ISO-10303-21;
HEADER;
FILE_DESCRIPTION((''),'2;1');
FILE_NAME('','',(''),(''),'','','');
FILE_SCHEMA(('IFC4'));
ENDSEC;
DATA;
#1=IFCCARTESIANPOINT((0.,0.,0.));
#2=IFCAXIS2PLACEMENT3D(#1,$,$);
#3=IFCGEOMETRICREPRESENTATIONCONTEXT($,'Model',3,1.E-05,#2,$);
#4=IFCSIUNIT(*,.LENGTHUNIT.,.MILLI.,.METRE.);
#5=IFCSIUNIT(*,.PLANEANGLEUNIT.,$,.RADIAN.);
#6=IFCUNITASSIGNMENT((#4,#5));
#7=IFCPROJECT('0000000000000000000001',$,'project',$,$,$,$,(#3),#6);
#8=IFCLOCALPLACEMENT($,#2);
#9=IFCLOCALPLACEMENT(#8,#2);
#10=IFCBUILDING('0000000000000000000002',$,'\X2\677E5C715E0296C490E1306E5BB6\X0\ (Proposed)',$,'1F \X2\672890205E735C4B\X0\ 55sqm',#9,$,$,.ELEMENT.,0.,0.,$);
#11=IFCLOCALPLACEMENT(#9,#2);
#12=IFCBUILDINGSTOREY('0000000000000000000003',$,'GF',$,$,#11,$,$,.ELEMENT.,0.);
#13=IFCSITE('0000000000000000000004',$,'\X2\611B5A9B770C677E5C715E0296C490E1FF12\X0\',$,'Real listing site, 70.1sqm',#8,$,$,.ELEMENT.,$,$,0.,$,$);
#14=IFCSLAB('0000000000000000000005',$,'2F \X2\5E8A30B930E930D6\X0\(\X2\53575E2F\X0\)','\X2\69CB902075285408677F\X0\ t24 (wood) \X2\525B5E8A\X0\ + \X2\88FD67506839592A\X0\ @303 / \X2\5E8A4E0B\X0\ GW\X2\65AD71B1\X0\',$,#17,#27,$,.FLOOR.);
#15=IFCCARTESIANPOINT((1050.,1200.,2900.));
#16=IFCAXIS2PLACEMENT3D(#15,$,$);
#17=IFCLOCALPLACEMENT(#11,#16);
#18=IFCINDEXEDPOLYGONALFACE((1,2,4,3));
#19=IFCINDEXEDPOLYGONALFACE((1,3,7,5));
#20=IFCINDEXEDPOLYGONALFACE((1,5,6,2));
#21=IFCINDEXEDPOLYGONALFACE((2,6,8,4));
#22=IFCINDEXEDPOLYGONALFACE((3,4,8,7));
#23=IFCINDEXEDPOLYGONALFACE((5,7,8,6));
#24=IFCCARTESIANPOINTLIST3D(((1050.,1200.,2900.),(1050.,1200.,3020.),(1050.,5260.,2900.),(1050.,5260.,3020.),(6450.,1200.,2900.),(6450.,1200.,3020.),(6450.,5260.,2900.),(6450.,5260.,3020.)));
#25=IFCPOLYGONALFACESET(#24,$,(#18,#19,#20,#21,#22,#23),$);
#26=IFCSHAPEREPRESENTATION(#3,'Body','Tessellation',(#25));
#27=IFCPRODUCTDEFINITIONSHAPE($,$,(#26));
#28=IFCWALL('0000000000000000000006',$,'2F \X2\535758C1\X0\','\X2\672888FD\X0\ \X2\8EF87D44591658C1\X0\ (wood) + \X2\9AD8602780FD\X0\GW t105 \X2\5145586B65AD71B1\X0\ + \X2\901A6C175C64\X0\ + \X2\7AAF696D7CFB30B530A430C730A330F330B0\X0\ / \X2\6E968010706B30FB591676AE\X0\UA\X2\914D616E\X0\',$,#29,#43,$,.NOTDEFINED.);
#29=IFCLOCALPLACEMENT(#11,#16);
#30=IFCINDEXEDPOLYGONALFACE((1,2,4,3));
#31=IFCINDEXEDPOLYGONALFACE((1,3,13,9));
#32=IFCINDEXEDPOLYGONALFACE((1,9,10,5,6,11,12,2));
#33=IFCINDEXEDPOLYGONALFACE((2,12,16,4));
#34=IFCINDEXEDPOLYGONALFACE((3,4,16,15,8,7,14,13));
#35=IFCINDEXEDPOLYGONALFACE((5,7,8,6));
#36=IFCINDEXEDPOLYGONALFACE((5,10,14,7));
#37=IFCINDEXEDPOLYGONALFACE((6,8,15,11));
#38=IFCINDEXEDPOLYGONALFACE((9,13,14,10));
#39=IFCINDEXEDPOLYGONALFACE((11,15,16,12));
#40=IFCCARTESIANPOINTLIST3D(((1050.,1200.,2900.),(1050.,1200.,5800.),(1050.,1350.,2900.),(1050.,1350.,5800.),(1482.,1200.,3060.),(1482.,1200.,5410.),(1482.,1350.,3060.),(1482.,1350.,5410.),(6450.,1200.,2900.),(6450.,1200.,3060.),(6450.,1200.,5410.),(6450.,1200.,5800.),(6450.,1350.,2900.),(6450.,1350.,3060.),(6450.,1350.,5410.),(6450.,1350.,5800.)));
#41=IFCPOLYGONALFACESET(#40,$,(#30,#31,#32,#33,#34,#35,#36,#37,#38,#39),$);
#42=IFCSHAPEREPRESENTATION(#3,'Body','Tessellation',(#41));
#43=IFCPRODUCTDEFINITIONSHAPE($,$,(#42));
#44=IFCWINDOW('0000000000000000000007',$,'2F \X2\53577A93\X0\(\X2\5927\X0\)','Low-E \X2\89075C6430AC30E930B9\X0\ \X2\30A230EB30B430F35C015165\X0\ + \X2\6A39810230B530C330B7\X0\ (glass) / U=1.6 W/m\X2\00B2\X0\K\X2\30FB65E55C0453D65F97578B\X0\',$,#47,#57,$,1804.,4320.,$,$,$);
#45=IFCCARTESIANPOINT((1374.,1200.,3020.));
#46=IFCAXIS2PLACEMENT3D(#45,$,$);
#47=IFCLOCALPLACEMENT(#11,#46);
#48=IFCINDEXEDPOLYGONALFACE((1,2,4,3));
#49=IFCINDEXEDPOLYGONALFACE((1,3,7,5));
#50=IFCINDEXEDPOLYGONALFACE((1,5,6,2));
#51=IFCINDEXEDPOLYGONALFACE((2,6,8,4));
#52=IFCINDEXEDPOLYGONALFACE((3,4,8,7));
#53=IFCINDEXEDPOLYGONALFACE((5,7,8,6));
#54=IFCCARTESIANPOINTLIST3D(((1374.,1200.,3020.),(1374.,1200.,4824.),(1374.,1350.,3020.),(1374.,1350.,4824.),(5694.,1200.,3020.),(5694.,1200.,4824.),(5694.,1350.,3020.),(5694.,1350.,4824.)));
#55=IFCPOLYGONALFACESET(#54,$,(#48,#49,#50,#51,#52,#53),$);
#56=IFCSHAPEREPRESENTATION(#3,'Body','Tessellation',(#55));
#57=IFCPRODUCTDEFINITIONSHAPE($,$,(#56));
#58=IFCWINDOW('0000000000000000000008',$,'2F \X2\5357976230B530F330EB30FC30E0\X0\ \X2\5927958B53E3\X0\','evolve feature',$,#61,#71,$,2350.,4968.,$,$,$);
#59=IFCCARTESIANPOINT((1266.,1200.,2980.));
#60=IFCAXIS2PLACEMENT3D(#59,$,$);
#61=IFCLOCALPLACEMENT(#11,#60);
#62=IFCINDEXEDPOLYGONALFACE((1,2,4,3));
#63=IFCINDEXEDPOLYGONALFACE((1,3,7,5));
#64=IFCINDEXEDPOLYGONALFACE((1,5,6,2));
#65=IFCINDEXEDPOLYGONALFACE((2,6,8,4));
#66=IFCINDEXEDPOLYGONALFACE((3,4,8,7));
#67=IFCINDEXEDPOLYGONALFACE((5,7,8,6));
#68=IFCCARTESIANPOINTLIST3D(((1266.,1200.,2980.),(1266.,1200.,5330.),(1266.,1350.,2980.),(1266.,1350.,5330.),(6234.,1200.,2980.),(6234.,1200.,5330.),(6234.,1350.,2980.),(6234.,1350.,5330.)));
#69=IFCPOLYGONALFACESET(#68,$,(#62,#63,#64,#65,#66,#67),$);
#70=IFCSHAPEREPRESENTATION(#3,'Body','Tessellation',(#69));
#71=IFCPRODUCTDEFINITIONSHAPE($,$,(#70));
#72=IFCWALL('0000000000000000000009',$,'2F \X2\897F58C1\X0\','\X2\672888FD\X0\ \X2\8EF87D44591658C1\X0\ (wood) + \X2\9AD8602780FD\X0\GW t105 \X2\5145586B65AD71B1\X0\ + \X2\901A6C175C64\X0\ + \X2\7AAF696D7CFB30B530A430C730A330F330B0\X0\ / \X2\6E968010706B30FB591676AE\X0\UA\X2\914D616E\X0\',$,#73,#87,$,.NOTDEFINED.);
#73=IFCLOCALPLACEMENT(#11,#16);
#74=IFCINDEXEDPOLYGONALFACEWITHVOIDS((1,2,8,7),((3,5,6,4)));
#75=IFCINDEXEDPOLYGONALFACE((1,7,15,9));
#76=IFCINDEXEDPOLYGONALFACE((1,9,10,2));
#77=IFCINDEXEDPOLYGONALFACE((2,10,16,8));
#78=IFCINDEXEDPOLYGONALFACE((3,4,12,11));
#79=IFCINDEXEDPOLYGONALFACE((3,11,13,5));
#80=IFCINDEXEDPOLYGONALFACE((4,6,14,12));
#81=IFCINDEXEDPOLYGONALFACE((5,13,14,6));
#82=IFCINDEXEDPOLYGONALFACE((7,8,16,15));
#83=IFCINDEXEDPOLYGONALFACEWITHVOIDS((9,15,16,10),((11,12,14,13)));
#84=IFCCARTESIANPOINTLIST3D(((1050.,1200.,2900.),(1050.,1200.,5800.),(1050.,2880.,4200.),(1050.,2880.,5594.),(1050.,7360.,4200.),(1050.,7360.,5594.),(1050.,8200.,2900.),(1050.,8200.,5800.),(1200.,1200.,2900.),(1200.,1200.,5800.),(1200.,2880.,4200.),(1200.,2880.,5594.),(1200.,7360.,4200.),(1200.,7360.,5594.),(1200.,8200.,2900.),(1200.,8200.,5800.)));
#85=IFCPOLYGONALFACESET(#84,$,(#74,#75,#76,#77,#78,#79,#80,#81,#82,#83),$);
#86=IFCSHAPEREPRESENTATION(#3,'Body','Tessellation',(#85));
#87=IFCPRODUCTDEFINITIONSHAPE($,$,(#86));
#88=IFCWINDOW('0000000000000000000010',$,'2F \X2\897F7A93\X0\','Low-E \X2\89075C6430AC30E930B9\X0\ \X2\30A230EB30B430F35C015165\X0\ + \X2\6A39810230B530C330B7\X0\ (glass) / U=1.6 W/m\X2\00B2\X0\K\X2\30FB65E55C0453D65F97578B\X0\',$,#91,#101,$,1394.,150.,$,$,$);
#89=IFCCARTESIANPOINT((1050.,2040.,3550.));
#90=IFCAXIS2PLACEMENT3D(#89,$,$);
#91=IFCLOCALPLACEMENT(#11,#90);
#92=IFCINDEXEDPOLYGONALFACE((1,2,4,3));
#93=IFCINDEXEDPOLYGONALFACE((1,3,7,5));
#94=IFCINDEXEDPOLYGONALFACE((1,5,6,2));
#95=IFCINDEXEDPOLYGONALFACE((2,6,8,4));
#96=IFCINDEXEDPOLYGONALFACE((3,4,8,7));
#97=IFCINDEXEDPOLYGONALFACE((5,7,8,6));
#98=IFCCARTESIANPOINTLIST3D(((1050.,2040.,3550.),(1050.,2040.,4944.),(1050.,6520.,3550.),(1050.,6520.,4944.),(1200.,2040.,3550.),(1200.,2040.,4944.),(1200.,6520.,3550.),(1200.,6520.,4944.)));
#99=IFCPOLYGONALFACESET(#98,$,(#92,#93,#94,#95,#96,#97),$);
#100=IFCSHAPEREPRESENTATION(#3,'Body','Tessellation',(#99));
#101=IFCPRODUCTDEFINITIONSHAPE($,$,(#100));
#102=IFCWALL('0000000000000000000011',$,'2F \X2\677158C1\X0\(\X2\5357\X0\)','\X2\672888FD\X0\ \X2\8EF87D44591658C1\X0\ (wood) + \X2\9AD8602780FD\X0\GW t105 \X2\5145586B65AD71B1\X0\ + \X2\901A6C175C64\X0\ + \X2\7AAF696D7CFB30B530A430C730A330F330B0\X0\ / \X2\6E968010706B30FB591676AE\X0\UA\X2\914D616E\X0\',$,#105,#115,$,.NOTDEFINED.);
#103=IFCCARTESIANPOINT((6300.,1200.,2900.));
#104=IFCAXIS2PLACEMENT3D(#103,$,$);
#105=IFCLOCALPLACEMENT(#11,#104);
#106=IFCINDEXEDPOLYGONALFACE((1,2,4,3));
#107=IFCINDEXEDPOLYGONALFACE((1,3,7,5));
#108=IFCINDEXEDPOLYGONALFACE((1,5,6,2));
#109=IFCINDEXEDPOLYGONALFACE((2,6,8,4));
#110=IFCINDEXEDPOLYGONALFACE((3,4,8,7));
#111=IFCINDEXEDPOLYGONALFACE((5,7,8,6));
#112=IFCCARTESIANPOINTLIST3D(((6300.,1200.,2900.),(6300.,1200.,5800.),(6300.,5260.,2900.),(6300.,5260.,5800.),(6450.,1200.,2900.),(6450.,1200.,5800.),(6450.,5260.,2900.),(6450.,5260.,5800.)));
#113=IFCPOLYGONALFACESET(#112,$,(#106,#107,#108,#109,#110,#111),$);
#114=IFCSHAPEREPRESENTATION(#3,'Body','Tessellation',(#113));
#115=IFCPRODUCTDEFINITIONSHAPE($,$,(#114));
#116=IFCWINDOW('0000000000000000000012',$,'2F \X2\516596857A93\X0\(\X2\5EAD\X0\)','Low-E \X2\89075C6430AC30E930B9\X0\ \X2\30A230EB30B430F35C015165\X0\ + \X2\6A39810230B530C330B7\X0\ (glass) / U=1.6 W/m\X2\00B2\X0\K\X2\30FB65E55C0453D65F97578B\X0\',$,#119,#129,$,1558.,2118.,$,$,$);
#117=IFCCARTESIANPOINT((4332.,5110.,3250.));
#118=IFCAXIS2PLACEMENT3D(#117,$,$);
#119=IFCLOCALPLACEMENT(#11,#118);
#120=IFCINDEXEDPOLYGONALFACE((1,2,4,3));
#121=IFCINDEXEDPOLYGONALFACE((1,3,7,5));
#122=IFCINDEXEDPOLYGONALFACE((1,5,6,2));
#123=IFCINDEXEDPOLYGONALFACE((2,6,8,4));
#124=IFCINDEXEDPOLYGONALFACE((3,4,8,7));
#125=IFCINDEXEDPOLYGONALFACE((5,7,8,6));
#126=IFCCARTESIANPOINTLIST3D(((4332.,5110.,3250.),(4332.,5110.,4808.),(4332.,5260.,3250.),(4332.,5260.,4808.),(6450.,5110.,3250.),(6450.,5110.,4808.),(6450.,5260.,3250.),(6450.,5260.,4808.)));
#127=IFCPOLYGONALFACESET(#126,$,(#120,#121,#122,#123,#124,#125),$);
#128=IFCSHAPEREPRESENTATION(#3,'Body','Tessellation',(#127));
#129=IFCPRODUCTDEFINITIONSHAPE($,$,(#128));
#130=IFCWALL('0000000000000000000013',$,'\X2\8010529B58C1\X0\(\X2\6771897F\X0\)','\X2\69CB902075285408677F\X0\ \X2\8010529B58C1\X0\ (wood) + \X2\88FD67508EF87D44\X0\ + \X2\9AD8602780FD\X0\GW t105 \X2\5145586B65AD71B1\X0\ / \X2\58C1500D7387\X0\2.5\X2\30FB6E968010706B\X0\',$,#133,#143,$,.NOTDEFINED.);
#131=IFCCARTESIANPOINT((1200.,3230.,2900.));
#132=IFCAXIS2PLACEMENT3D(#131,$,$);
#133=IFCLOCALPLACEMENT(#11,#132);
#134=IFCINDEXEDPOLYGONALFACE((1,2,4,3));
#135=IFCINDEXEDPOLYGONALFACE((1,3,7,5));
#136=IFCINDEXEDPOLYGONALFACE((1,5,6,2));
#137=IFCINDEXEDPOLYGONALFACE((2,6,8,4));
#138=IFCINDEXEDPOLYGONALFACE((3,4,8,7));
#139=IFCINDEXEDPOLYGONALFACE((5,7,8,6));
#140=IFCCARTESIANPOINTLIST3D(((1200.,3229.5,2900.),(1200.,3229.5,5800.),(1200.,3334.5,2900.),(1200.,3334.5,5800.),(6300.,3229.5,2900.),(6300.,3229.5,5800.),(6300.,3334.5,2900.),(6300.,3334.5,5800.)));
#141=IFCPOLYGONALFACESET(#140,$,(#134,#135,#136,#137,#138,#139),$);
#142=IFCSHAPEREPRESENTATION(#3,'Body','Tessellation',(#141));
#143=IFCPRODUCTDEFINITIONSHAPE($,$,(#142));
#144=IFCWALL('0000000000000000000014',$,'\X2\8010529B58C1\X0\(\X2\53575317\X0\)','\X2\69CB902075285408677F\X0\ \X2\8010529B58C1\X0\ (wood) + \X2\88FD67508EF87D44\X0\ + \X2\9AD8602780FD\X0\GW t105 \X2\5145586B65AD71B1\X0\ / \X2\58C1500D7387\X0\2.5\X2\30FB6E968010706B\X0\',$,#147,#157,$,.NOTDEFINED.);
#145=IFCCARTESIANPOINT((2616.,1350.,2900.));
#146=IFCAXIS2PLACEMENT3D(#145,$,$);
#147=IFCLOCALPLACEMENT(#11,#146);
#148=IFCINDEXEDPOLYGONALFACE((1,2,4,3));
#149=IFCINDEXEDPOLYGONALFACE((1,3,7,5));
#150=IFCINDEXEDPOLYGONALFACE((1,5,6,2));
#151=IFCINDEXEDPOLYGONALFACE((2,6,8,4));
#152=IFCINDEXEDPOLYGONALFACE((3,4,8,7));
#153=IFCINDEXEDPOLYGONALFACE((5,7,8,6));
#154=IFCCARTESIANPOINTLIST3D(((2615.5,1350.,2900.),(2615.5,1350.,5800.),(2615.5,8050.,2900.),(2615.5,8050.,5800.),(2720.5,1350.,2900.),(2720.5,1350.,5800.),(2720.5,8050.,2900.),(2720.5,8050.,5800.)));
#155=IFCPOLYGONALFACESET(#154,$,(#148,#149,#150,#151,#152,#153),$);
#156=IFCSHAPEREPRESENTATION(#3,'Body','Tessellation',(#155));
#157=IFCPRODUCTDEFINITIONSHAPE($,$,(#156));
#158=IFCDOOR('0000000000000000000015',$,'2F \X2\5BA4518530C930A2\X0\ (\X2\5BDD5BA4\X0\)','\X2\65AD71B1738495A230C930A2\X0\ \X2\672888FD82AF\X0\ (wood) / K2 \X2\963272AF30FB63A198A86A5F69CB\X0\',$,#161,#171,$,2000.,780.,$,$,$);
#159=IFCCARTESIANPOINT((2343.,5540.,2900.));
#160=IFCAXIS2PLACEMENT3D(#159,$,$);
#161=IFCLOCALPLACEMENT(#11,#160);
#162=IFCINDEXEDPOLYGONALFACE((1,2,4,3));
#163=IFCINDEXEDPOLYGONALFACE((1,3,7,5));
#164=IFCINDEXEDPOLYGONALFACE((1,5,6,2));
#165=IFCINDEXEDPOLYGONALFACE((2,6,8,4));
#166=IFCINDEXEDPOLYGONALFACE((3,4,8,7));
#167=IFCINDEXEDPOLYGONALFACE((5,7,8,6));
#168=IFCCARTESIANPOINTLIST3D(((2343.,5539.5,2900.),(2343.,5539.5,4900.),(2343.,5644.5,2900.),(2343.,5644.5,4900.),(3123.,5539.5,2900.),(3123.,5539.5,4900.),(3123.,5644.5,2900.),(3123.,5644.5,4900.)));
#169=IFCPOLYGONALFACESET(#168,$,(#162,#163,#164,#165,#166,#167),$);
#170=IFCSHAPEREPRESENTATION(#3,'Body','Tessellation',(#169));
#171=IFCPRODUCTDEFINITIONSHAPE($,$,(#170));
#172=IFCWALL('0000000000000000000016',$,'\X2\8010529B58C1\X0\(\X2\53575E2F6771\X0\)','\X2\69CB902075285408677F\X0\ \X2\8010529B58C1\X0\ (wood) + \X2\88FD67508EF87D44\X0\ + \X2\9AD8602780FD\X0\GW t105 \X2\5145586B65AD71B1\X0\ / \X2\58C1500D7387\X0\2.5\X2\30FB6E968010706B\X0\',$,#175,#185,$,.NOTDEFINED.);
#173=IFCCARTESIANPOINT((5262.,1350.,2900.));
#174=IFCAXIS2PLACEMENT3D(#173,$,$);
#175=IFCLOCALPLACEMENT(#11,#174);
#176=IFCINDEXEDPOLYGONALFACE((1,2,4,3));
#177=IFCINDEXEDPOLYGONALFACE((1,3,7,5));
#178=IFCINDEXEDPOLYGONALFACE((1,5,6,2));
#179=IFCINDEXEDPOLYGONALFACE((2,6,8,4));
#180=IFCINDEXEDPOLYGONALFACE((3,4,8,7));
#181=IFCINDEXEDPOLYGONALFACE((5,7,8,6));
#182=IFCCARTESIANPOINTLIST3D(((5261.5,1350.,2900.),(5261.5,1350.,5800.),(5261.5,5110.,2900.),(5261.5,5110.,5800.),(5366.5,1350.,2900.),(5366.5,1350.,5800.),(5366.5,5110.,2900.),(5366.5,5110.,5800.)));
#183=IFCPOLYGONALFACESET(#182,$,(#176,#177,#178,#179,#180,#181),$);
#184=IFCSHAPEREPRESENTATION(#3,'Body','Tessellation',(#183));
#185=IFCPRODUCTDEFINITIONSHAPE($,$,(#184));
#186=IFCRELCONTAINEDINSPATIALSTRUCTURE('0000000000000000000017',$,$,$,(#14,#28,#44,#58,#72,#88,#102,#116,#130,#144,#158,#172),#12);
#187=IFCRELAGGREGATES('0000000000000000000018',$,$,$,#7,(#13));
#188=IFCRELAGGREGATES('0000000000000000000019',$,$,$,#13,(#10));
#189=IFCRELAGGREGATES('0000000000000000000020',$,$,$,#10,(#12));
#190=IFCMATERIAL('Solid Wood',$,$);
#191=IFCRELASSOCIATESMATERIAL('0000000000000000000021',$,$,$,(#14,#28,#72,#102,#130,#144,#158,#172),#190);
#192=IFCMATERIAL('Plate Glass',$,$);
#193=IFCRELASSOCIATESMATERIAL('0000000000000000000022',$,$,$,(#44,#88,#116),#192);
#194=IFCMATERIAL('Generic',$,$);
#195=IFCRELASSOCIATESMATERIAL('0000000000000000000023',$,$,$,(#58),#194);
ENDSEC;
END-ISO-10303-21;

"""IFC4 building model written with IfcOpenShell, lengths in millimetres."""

from ifc_helpers import new_model, si_unit, frame, frame_2d, origin, place, context, project, spatial, rectangle, extrude, material, element, fill, save


model = new_model("IFC4")

# Units and contexts
model_context = context("Model", 3, precision=1e-05, world=origin())
ifc_project = project(units=[si_unit("LENGTHUNIT", "METRE", prefix="MILLI"), si_unit("PLANEANGLEUNIT", "RADIAN")], contexts=[model_context])

# Site, building, storey
site_placement = place(None, origin())
site = spatial("IfcSite", under=ifc_project, at=site_placement, Name="愛媛県松山市雄郡２", ObjectType="Real listing site, 70.1sqm", CompositionType="ELEMENT", RefElevation=0.0)
building_placement = place(site_placement, origin())
building = spatial("IfcBuilding", under=site, at=building_placement, Name="松山市雄郡の家 (Proposed)", ObjectType="1F 木造平屋 55sqm", CompositionType="ELEMENT", ElevationOfRefHeight=0.0, ElevationOfTerrain=0.0)
storey_placement = place(building_placement, origin())
storey = spatial("IfcBuildingStorey", under=building, at=storey_placement, Name="GF", CompositionType="ELEMENT", Elevation=0.0)

# Slab
ifc_material_1 = material(Name="Solid Wood")
slab_placement = place(storey_placement, frame((1050.0, 1200.0, 2900.0)))
element("IfcSlab", 1, at=slab_placement, inside=storey, material=ifc_material_1, Name="2F 床スラブ(南帯)", Description="構造用合板 t24 (wood) 剛床 + 製材根太 @303 / 床下 GW断熱", PredefinedType="FLOOR", context=model_context, shape_type="SweptSolid", body=[
    extrude(rectangle(XDim=5400.0, YDim=4060.0, at=frame_2d((2700.0, 2030.0))), frame((1050.0, 1200.0, 2900.0)), (0.0, 0.0, 1.0), 120.0),
])

# Wall, openings, windows
wall_1_placement = place(storey_placement, frame((1050.0, 1200.0, 2900.0)))
wall_1 = element("IfcWall", 2, at=wall_1_placement, inside=storey, material=ifc_material_1, Name="2F 南壁", Description="木製 軸組外壁 (wood) + 高性能GW t105 充填断熱 + 通気層 + 窯業系サイディング / 準耐火・外皮UA配慮", PredefinedType="NOTDEFINED", context=model_context, shape_type="SweptSolid", body=[
    extrude(rectangle(XDim=5400.0, YDim=150.0, at=frame_2d((2700.0, 75.0))), frame((1050.0, 1200.0, 2900.0)), (0.0, 0.0, 1.0), 2900.0),
])
opening_1_placement = place(storey_placement, frame((1374.0, 1200.0, 3020.0)))
opening_1 = element("IfcOpeningElement", 3, at=opening_1_placement, cuts=wall_1, PredefinedType="NOTDEFINED", context=model_context, shape_type="SweptSolid", body=[
    extrude(rectangle(XDim=4320.0, YDim=150.0, at=frame_2d((2160.0, 75.0))), frame((1374.0, 1200.0, 3020.0)), (0.0, 0.0, 1.0), 1804.0),
])
opening_2_placement = place(storey_placement, frame((1266.0, 1200.0, 2980.0)))
opening_2 = element("IfcOpeningElement", 4, at=opening_2_placement, cuts=wall_1, PredefinedType="NOTDEFINED", context=model_context, shape_type="SweptSolid", body=[
    extrude(rectangle(XDim=4968.0, YDim=150.0, at=frame_2d((2484.0, 75.0))), frame((1266.0, 1200.0, 2980.0)), (0.0, 0.0, 1.0), 2350.0),
])
ifc_material_2 = material(Name="Plate Glass")
window_1_placement = place(storey_placement, frame((1374.0, 1200.0, 3020.0)))
window_1 = element("IfcWindow", 5, at=window_1_placement, inside=storey, material=ifc_material_2, Name="2F 南窓(大)", Description="Low-E 複層ガラス アルゴン封入 + 樹脂サッシ (glass) / U=1.6 W/m²K・日射取得型", OverallHeight=1804.0, OverallWidth=4320.0, context=model_context, shape_type="SweptSolid", body=[
    extrude(rectangle(XDim=4320.0, YDim=150.0, at=frame_2d((2160.0, 75.0))), frame((1374.0, 1200.0, 3020.0)), (0.0, 0.0, 1.0), 1804.0),
])
fill(opening_1, window_1)
ifc_material_3 = material(Name="Generic")
window_2_placement = place(storey_placement, frame((1266.0, 1200.0, 2980.0)))
window_2 = element("IfcWindow", 6, at=window_2_placement, inside=storey, material=ifc_material_3, Name="2F 南面サンルーム 大開口", Description="evolve feature", OverallHeight=2350.0, OverallWidth=4968.0, context=model_context, shape_type="SweptSolid", body=[
    extrude(rectangle(XDim=4968.0, YDim=150.0, at=frame_2d((2484.0, 75.0))), frame((1266.0, 1200.0, 2980.0)), (0.0, 0.0, 1.0), 2350.0),
])
fill(opening_2, window_2)

# Walls, openings, windows
wall_2_placement = place(storey_placement, frame((1050.0, 1200.0, 2900.0)))
wall_2 = element("IfcWall", 7, at=wall_2_placement, inside=storey, material=ifc_material_1, Name="2F 西壁", Description="木製 軸組外壁 (wood) + 高性能GW t105 充填断熱 + 通気層 + 窯業系サイディング / 準耐火・外皮UA配慮", PredefinedType="NOTDEFINED", context=model_context, shape_type="SweptSolid", body=[
    extrude(rectangle(XDim=150.0, YDim=7000.0, at=frame_2d((75.0, 3500.0))), frame((1050.0, 1200.0, 2900.0)), (0.0, 0.0, 1.0), 2900.0),
])
opening_3_placement = place(storey_placement, frame((1050.0, 2040.0, 3550.0)))
opening_3 = element("IfcOpeningElement", 8, at=opening_3_placement, cuts=wall_2, PredefinedType="NOTDEFINED", context=model_context, shape_type="SweptSolid", body=[
    extrude(rectangle(XDim=150.0, YDim=4480.0, at=frame_2d((75.0, 2240.0))), frame((1050.0, 2040.0, 3550.0)), (0.0, 0.0, 1.0), 1394.0),
])
window_3_placement = place(storey_placement, frame((1050.0, 2040.0, 3550.0)))
window_3 = element("IfcWindow", 9, at=window_3_placement, inside=storey, material=ifc_material_2, Name="2F 西窓", Description="Low-E 複層ガラス アルゴン封入 + 樹脂サッシ (glass) / U=1.6 W/m²K・日射取得型", OverallHeight=1394.0, OverallWidth=150.0, context=model_context, shape_type="SweptSolid", body=[
    extrude(rectangle(XDim=150.0, YDim=4480.0, at=frame_2d((75.0, 2240.0))), frame((1050.0, 2040.0, 3550.0)), (0.0, 0.0, 1.0), 1394.0),
])
fill(opening_3, window_3)
wall_3_placement = place(storey_placement, frame((6300.0, 1200.0, 2900.0)))
wall_3 = element("IfcWall", 10, at=wall_3_placement, inside=storey, material=ifc_material_1, Name="2F 東壁(南)", Description="木製 軸組外壁 (wood) + 高性能GW t105 充填断熱 + 通気層 + 窯業系サイディング / 準耐火・外皮UA配慮", PredefinedType="NOTDEFINED", context=model_context, shape_type="SweptSolid", body=[
    extrude(rectangle(XDim=150.0, YDim=4060.0, at=frame_2d((75.0, 2030.0))), frame((6300.0, 1200.0, 2900.0)), (0.0, 0.0, 1.0), 2900.0),
])
opening_4_placement = place(storey_placement, frame((4332.0, 5110.0, 3250.0)))
opening_4 = element("IfcOpeningElement", 11, at=opening_4_placement, cuts=wall_3, PredefinedType="NOTDEFINED", context=model_context, shape_type="SweptSolid", body=[
    extrude(rectangle(XDim=2118.0, YDim=150.0, at=frame_2d((1059.0, 75.0))), frame((4332.0, 5110.0, 3250.0)), (0.0, 0.0, 1.0), 1558.0),
])
window_4_placement = place(storey_placement, frame((4332.0, 5110.0, 3250.0)))
window_4 = element("IfcWindow", 12, at=window_4_placement, inside=storey, material=ifc_material_2, Name="2F 入隅窓(庭)", Description="Low-E 複層ガラス アルゴン封入 + 樹脂サッシ (glass) / U=1.6 W/m²K・日射取得型", OverallHeight=1558.0, OverallWidth=2118.0, context=model_context, shape_type="SweptSolid", body=[
    extrude(rectangle(XDim=2118.0, YDim=150.0, at=frame_2d((1059.0, 75.0))), frame((4332.0, 5110.0, 3250.0)), (0.0, 0.0, 1.0), 1558.0),
])
fill(opening_4, window_4)

# Wall
wall_4_placement = place(storey_placement, frame((1200.0, 3230.0, 2900.0)))
element("IfcWall", 13, at=wall_4_placement, inside=storey, material=ifc_material_1, Name="耐力壁(東西)", Description="構造用合板 耐力壁 (wood) + 製材軸組 + 高性能GW t105 充填断熱 / 壁倍率2.5・準耐火", PredefinedType="NOTDEFINED", context=model_context, shape_type="SweptSolid", body=[
    extrude(rectangle(XDim=5100.0, YDim=105.0, at=frame_2d((2550.0, 52.0))), frame((1200.0, 3230.0, 2900.0)), (0.0, 0.0, 1.0), 2900.0),
])

# Wall, opening, door
wall_5_placement = place(storey_placement, frame((2616.0, 1350.0, 2900.0)))
wall_5 = element("IfcWall", 14, at=wall_5_placement, inside=storey, material=ifc_material_1, Name="耐力壁(南北)", Description="構造用合板 耐力壁 (wood) + 製材軸組 + 高性能GW t105 充填断熱 / 壁倍率2.5・準耐火", PredefinedType="NOTDEFINED", context=model_context, shape_type="SweptSolid", body=[
    extrude(rectangle(XDim=105.0, YDim=6700.0, at=frame_2d((52.0, 3350.0))), frame((2616.0, 1350.0, 2900.0)), (0.0, 0.0, 1.0), 2900.0),
])
opening_5_placement = place(storey_placement, frame((2343.0, 5540.0, 2900.0)))
opening_5 = element("IfcOpeningElement", 15, at=opening_5_placement, cuts=wall_5, PredefinedType="NOTDEFINED", context=model_context, shape_type="SweptSolid", body=[
    extrude(rectangle(XDim=780.0, YDim=105.0, at=frame_2d((390.0, 52.0))), frame((2343.0, 5540.0, 2900.0)), (0.0, 0.0, 1.0), 2000.0),
])
door_placement = place(storey_placement, frame((2343.0, 5540.0, 2900.0)))
door = element("IfcDoor", 16, at=door_placement, inside=storey, material=ifc_material_1, Name="2F 室内ドア (寝室)", Description="断熱玄関ドア 木製芯 (wood) / K2 防犯・採風機構", OverallHeight=2000.0, OverallWidth=780.0, context=model_context, shape_type="SweptSolid", body=[
    extrude(rectangle(XDim=780.0, YDim=105.0, at=frame_2d((390.0, 52.0))), frame((2343.0, 5540.0, 2900.0)), (0.0, 0.0, 1.0), 2000.0),
])
fill(opening_5, door)

# Wall
wall_6_placement = place(storey_placement, frame((5262.0, 1350.0, 2900.0)))
element("IfcWall", 17, at=wall_6_placement, inside=storey, material=ifc_material_1, Name="耐力壁(南帯東)", Description="構造用合板 耐力壁 (wood) + 製材軸組 + 高性能GW t105 充填断熱 / 壁倍率2.5・準耐火", PredefinedType="NOTDEFINED", context=model_context, shape_type="SweptSolid", body=[
    extrude(rectangle(XDim=105.0, YDim=3760.0, at=frame_2d((52.0, 1880.0))), frame((5262.0, 1350.0, 2900.0)), (0.0, 0.0, 1.0), 2900.0),
])

save(model, "model.ifc")
